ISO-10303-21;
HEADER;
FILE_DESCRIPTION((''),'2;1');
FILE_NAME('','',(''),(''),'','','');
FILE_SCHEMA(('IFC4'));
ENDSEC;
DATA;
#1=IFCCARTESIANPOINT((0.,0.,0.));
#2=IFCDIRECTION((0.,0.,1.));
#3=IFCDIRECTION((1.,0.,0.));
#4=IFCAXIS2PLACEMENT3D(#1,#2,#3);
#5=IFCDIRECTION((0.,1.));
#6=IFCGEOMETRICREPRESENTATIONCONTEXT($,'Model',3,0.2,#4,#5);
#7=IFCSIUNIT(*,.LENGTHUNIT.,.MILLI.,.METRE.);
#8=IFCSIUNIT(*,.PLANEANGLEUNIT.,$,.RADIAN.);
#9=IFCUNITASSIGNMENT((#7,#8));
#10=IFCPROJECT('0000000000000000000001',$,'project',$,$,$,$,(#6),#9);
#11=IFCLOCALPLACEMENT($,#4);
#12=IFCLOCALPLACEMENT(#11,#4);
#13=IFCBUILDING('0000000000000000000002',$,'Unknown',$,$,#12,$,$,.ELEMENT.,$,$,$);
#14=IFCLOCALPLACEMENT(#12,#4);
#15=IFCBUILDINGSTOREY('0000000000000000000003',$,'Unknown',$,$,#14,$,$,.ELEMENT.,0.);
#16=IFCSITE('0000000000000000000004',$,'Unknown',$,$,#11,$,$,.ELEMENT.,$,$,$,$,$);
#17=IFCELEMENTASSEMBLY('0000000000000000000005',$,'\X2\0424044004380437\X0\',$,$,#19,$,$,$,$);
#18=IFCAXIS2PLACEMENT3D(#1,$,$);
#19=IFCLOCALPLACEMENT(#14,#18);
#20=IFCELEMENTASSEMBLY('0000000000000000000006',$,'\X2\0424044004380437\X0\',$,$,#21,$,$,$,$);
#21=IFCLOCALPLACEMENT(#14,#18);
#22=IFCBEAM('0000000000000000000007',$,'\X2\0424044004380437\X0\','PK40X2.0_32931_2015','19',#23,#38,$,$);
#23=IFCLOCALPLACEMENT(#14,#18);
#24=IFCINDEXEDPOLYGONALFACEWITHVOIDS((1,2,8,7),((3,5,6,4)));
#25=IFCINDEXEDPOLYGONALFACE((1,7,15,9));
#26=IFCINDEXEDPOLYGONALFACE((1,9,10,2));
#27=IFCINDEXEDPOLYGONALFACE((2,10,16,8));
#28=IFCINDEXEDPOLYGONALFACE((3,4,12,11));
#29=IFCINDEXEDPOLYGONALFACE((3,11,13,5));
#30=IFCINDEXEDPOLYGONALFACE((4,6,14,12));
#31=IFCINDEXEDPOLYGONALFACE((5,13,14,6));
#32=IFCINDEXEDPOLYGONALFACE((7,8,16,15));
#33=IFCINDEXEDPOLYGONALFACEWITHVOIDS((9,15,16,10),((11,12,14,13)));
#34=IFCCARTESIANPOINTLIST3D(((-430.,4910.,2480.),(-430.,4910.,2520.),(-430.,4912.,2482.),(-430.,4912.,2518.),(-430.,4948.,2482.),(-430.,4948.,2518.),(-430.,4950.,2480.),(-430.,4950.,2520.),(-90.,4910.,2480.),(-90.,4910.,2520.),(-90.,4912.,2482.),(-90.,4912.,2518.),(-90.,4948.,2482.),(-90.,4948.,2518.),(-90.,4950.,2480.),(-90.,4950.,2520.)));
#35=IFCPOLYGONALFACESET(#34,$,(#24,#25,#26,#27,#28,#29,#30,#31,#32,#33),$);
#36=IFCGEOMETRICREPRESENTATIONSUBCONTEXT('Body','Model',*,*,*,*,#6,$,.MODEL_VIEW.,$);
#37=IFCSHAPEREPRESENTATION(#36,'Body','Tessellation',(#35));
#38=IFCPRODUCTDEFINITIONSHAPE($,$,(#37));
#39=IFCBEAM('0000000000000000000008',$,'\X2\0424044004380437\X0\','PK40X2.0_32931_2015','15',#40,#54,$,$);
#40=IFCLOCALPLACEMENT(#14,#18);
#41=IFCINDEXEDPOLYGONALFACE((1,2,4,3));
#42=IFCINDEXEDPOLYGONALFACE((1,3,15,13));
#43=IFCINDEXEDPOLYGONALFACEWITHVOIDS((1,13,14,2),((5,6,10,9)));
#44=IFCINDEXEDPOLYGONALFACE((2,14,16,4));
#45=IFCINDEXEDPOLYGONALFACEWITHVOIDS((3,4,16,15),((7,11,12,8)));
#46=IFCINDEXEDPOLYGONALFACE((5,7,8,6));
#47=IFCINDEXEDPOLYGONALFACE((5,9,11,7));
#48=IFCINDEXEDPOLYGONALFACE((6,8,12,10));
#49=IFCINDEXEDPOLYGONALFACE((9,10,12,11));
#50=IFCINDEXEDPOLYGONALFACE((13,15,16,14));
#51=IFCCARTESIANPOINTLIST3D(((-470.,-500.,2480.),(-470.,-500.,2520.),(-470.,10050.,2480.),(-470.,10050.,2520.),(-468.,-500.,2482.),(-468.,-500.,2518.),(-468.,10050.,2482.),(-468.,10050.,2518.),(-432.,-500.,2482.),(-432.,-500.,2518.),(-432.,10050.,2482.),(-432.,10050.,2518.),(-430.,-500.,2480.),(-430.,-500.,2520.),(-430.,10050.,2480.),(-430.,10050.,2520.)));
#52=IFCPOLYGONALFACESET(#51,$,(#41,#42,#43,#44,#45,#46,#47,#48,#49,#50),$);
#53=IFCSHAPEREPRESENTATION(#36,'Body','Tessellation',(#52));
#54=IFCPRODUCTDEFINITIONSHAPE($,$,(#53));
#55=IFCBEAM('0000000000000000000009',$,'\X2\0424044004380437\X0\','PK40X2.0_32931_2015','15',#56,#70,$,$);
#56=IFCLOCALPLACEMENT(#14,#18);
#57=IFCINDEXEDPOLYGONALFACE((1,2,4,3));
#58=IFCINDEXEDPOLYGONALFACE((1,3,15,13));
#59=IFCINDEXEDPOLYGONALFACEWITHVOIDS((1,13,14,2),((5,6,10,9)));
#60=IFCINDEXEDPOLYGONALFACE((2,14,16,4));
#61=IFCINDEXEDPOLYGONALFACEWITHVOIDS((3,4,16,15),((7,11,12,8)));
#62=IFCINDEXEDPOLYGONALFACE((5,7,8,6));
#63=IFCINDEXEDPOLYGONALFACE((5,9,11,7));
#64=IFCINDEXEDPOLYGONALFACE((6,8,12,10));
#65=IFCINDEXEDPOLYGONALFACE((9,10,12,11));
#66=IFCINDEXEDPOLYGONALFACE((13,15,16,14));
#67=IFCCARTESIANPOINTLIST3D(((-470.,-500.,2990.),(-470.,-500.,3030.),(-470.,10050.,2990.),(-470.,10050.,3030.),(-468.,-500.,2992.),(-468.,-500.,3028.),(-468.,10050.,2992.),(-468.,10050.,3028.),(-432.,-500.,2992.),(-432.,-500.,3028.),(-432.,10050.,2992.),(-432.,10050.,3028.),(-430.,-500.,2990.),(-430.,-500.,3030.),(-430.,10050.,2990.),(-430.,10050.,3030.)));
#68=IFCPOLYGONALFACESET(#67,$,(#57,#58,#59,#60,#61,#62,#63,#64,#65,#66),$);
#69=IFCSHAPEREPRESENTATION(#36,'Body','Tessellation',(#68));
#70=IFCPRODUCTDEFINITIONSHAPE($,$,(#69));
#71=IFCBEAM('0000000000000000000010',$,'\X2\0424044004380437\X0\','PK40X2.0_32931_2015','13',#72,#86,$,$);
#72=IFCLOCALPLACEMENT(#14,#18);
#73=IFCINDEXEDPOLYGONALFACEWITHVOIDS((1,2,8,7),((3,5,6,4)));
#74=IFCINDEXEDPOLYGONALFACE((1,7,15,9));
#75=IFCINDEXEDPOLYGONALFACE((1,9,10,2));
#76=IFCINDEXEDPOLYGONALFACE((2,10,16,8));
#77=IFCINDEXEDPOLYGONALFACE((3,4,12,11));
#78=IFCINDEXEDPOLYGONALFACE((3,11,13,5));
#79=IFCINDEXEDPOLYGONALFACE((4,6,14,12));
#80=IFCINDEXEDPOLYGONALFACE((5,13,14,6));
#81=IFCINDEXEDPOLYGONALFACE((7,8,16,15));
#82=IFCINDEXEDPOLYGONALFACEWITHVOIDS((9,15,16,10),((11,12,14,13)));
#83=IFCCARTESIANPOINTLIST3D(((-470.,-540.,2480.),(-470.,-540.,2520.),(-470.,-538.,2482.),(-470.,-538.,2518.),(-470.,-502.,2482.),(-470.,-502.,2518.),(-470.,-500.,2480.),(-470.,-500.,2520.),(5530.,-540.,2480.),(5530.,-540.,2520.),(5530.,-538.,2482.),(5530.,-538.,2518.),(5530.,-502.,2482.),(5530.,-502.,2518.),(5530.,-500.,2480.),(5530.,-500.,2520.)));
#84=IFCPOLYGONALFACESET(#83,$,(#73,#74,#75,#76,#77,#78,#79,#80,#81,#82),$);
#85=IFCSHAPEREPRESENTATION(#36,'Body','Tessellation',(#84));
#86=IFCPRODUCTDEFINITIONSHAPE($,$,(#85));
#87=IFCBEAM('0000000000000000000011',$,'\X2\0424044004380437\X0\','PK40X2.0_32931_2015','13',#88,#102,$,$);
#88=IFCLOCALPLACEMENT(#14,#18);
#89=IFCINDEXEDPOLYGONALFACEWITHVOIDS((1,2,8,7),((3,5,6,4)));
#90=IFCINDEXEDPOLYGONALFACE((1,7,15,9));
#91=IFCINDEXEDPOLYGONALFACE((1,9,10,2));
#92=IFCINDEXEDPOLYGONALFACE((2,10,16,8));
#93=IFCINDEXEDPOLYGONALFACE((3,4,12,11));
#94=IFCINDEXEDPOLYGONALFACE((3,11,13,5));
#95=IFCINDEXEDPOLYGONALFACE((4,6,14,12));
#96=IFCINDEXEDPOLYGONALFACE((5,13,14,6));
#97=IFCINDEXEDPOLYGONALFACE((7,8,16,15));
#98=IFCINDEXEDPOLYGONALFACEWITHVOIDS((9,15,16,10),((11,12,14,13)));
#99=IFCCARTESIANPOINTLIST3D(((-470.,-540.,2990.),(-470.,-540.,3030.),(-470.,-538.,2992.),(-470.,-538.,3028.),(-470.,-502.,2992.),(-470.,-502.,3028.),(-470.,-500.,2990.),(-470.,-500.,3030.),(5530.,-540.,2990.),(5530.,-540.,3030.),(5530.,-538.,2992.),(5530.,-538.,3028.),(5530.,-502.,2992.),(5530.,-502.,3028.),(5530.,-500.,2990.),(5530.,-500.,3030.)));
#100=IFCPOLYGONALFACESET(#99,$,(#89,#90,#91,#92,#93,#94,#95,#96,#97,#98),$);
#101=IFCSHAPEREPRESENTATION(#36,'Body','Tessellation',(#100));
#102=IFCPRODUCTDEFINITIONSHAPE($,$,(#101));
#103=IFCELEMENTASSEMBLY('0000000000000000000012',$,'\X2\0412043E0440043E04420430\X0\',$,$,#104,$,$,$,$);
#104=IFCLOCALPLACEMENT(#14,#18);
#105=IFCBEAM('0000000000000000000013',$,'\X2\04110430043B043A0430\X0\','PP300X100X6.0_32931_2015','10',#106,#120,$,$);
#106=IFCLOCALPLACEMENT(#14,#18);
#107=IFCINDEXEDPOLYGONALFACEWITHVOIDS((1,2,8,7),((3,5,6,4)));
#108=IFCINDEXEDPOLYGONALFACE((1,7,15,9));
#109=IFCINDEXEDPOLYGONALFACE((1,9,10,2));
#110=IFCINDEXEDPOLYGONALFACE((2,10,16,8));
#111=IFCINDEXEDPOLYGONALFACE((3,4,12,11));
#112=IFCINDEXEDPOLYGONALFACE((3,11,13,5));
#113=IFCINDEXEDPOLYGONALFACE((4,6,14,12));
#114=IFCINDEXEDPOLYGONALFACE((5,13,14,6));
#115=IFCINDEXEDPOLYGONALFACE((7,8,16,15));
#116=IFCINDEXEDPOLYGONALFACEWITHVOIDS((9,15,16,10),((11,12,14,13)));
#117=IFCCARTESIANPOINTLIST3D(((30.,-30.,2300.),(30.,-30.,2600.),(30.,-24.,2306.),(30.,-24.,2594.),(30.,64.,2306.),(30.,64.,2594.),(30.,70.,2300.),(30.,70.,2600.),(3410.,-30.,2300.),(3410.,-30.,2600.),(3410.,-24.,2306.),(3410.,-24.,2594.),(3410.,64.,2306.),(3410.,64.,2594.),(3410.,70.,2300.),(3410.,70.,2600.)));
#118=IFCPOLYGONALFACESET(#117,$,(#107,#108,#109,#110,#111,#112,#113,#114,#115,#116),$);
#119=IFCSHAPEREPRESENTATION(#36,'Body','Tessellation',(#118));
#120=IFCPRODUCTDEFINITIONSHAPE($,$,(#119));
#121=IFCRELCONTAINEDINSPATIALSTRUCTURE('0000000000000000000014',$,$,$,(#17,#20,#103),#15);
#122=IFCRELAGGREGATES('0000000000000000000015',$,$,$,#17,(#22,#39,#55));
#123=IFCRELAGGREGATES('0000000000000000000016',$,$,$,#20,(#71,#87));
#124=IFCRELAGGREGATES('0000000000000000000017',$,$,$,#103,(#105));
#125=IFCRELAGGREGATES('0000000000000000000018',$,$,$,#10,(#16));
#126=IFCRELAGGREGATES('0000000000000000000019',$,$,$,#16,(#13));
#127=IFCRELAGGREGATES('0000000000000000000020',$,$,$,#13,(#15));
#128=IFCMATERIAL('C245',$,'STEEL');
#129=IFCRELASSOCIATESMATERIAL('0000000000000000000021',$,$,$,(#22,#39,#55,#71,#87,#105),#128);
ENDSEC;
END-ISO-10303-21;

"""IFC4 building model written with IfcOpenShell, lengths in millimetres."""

from ifc_helpers import new_model, si_unit, direction, frame, origin_with_axes, place, context, subcontext, project, spatial, line, indexed_curve, outline, extrude, material, element, aggregate, save


model = new_model("IFC4")

# Units and contexts
model_context = context("Model", 3, precision=0.2, world=origin_with_axes(), true_north=direction((0.0, 1.0)))
body_context = subcontext(model_context, "Body", "Model", "MODEL_VIEW")
ifc_project = project(units=[si_unit("LENGTHUNIT", "METRE", prefix="MILLI"), si_unit("PLANEANGLEUNIT", "RADIAN")], contexts=[model_context])

# Site, building, storey
site_placement = place(None, origin_with_axes())
site = spatial("IfcSite", under=ifc_project, at=site_placement, Name="Unknown", CompositionType="ELEMENT")
building_placement = place(site_placement, origin_with_axes())
building = spatial("IfcBuilding", under=site, at=building_placement, Name="Unknown", CompositionType="ELEMENT")
storey_placement = place(building_placement, origin_with_axes())
storey = spatial("IfcBuildingStorey", under=building, at=storey_placement, Name="Unknown", CompositionType="ELEMENT", Elevation=0.0)

# Element assemblies
assembly_1_placement = place(storey_placement, frame((-450.0, -500.0, 3010.0), z_axis=(1.0, 0.0, 0.0), x_axis=(0.0, 1.0, 0.0)))
assembly_1 = element("IfcElementAssembly", 1, at=assembly_1_placement, inside=storey, Name="Фриз")
ifc_material = material(Name="C245", Category="STEEL")
assembly_2_placement = place(storey_placement, frame((-470.0, -520.0, 3010.0), z_axis=(0.0, -1.0, 0.0), x_axis=(1.0, 0.0, 0.0)))
assembly_2 = element("IfcElementAssembly", 2, at=assembly_2_placement, inside=storey, Name="Фриз")

# Beams
beam_1_placement = place(assembly_1_placement, frame((5430.0, -510.0, 20.0), z_axis=(-1.0, 0.0, 0.0), x_axis=(0.0, 0.0, 1.0)))
beam_1 = element("IfcBeam", 3, at=beam_1_placement, material=ifc_material, Name="Фриз", Description="PK40X2.0_32931_2015", ObjectType="19", context=body_context, shape_type="SolidModel", body=[
    extrude(outline(indexed_curve([(-20.0, -20.0), (20.0, -20.0), (20.0, 20.0), (-20.0, 20.0)], segments=[line(1, 2, 3, 4, 1)]), holes=[indexed_curve([(-18.0, -18.0), (-18.0, 18.0), (18.0, 18.0), (18.0, -18.0)], segments=[line(1, 2, 3, 4, 1)])]), frame((0.0, 0.0, 0.0), z_axis=(-1.0, 0.0, 0.0), x_axis=(0.0, 0.0, 1.0)), (0.0, 0.0, -1.0), 340.0),
])
beam_2_placement = place(assembly_1_placement, frame((0.0, -510.0, 0.0), z_axis=(0.0, 0.0, 1.0), x_axis=(1.0, 0.0, 0.0)))
beam_2 = element("IfcBeam", 4, at=beam_2_placement, material=ifc_material, Name="Фриз", Description="PK40X2.0_32931_2015", ObjectType="15", context=body_context, shape_type="SolidModel", body=[
    extrude(outline(indexed_curve([(-20.0, -20.0), (20.0, -20.0), (20.0, 20.0), (-20.0, 20.0)], segments=[line(1, 2, 3, 4, 1)]), holes=[indexed_curve([(-18.0, -18.0), (-18.0, 18.0), (18.0, 18.0), (18.0, -18.0)], segments=[line(1, 2, 3, 4, 1)])]), frame((0.0, 0.0, 0.0), z_axis=(-1.0, 0.0, 0.0), x_axis=(0.0, 0.0, 1.0)), (0.0, 0.0, -1.0), 10550.0),
])
beam_3_placement = place(assembly_1_placement, origin_with_axes())
beam_3 = element("IfcBeam", 5, at=beam_3_placement, material=ifc_material, Name="Фриз", Description="PK40X2.0_32931_2015", ObjectType="15", context=body_context, shape_type="SolidModel", body=[
    extrude(outline(indexed_curve([(-20.0, -20.0), (20.0, -20.0), (20.0, 20.0), (-20.0, 20.0)], segments=[line(1, 2, 3, 4, 1)]), holes=[indexed_curve([(-18.0, -18.0), (-18.0, 18.0), (18.0, 18.0), (18.0, -18.0)], segments=[line(1, 2, 3, 4, 1)])]), frame((0.0, 0.0, 0.0), z_axis=(-1.0, 0.0, 0.0), x_axis=(0.0, 0.0, 1.0)), (0.0, 0.0, -1.0), 10550.0),
])
aggregate(assembly_1, [beam_1, beam_2, beam_3])
beam_4_placement = place(assembly_2_placement, frame((0.0, -510.0, 0.0), z_axis=(0.0, 0.0, 1.0), x_axis=(1.0, 0.0, 0.0)))
beam_4 = element("IfcBeam", 6, at=beam_4_placement, material=ifc_material, Name="Фриз", Description="PK40X2.0_32931_2015", ObjectType="13", context=body_context, shape_type="SolidModel", body=[
    extrude(outline(indexed_curve([(-20.0, -20.0), (20.0, -20.0), (20.0, 20.0), (-20.0, 20.0)], segments=[line(1, 2, 3, 4, 1)]), holes=[indexed_curve([(-18.0, -18.0), (-18.0, 18.0), (18.0, 18.0), (18.0, -18.0)], segments=[line(1, 2, 3, 4, 1)])]), frame((0.0, 0.0, 0.0), z_axis=(-1.0, 0.0, 0.0), x_axis=(0.0, 0.0, 1.0)), (0.0, 0.0, -1.0), 6000.0),
])
beam_5_placement = place(assembly_2_placement, origin_with_axes())
beam_5 = element("IfcBeam", 7, at=beam_5_placement, material=ifc_material, Name="Фриз", Description="PK40X2.0_32931_2015", ObjectType="13", context=body_context, shape_type="SolidModel", body=[
    extrude(outline(indexed_curve([(-20.0, -20.0), (20.0, -20.0), (20.0, 20.0), (-20.0, 20.0)], segments=[line(1, 2, 3, 4, 1)]), holes=[indexed_curve([(-18.0, -18.0), (-18.0, 18.0), (18.0, 18.0), (18.0, -18.0)], segments=[line(1, 2, 3, 4, 1)])]), frame((0.0, 0.0, 0.0), z_axis=(-1.0, 0.0, 0.0), x_axis=(0.0, 0.0, 1.0)), (0.0, 0.0, -1.0), 6000.0),
])
aggregate(assembly_2, [beam_4, beam_5])

# Element assembly, beam
assembly_3_placement = place(storey_placement, frame((30.0, 20.0, 2450.0), z_axis=(0.0, -1.0, 0.0), x_axis=(1.0, 0.0, 0.0)))
assembly_3 = element("IfcElementAssembly", 8, at=assembly_3_placement, inside=storey, Name="Ворота")
beam_6_placement = place(assembly_3_placement, origin_with_axes())
beam_6 = element("IfcBeam", 9, at=beam_6_placement, material=ifc_material, Name="Балка", Description="PP300X100X6.0_32931_2015", ObjectType="10", context=body_context, shape_type="SolidModel", body=[
    extrude(outline(indexed_curve([(-50.0, -150.0), (50.0, -150.0), (50.0, 150.0), (-50.0, 150.0)], segments=[line(1, 2, 3, 4, 1)]), holes=[indexed_curve([(-44.0, -144.0), (-44.0, 144.0), (44.0, 144.0), (44.0, -144.0)], segments=[line(1, 2, 3, 4, 1)])]), frame((0.0, 0.0, 0.0), z_axis=(-1.0, 0.0, 0.0), x_axis=(0.0, 0.0, 1.0)), (0.0, 0.0, -1.0), 3380.0),
])
aggregate(assembly_3, [beam_6])

save(model, "model.ifc")
